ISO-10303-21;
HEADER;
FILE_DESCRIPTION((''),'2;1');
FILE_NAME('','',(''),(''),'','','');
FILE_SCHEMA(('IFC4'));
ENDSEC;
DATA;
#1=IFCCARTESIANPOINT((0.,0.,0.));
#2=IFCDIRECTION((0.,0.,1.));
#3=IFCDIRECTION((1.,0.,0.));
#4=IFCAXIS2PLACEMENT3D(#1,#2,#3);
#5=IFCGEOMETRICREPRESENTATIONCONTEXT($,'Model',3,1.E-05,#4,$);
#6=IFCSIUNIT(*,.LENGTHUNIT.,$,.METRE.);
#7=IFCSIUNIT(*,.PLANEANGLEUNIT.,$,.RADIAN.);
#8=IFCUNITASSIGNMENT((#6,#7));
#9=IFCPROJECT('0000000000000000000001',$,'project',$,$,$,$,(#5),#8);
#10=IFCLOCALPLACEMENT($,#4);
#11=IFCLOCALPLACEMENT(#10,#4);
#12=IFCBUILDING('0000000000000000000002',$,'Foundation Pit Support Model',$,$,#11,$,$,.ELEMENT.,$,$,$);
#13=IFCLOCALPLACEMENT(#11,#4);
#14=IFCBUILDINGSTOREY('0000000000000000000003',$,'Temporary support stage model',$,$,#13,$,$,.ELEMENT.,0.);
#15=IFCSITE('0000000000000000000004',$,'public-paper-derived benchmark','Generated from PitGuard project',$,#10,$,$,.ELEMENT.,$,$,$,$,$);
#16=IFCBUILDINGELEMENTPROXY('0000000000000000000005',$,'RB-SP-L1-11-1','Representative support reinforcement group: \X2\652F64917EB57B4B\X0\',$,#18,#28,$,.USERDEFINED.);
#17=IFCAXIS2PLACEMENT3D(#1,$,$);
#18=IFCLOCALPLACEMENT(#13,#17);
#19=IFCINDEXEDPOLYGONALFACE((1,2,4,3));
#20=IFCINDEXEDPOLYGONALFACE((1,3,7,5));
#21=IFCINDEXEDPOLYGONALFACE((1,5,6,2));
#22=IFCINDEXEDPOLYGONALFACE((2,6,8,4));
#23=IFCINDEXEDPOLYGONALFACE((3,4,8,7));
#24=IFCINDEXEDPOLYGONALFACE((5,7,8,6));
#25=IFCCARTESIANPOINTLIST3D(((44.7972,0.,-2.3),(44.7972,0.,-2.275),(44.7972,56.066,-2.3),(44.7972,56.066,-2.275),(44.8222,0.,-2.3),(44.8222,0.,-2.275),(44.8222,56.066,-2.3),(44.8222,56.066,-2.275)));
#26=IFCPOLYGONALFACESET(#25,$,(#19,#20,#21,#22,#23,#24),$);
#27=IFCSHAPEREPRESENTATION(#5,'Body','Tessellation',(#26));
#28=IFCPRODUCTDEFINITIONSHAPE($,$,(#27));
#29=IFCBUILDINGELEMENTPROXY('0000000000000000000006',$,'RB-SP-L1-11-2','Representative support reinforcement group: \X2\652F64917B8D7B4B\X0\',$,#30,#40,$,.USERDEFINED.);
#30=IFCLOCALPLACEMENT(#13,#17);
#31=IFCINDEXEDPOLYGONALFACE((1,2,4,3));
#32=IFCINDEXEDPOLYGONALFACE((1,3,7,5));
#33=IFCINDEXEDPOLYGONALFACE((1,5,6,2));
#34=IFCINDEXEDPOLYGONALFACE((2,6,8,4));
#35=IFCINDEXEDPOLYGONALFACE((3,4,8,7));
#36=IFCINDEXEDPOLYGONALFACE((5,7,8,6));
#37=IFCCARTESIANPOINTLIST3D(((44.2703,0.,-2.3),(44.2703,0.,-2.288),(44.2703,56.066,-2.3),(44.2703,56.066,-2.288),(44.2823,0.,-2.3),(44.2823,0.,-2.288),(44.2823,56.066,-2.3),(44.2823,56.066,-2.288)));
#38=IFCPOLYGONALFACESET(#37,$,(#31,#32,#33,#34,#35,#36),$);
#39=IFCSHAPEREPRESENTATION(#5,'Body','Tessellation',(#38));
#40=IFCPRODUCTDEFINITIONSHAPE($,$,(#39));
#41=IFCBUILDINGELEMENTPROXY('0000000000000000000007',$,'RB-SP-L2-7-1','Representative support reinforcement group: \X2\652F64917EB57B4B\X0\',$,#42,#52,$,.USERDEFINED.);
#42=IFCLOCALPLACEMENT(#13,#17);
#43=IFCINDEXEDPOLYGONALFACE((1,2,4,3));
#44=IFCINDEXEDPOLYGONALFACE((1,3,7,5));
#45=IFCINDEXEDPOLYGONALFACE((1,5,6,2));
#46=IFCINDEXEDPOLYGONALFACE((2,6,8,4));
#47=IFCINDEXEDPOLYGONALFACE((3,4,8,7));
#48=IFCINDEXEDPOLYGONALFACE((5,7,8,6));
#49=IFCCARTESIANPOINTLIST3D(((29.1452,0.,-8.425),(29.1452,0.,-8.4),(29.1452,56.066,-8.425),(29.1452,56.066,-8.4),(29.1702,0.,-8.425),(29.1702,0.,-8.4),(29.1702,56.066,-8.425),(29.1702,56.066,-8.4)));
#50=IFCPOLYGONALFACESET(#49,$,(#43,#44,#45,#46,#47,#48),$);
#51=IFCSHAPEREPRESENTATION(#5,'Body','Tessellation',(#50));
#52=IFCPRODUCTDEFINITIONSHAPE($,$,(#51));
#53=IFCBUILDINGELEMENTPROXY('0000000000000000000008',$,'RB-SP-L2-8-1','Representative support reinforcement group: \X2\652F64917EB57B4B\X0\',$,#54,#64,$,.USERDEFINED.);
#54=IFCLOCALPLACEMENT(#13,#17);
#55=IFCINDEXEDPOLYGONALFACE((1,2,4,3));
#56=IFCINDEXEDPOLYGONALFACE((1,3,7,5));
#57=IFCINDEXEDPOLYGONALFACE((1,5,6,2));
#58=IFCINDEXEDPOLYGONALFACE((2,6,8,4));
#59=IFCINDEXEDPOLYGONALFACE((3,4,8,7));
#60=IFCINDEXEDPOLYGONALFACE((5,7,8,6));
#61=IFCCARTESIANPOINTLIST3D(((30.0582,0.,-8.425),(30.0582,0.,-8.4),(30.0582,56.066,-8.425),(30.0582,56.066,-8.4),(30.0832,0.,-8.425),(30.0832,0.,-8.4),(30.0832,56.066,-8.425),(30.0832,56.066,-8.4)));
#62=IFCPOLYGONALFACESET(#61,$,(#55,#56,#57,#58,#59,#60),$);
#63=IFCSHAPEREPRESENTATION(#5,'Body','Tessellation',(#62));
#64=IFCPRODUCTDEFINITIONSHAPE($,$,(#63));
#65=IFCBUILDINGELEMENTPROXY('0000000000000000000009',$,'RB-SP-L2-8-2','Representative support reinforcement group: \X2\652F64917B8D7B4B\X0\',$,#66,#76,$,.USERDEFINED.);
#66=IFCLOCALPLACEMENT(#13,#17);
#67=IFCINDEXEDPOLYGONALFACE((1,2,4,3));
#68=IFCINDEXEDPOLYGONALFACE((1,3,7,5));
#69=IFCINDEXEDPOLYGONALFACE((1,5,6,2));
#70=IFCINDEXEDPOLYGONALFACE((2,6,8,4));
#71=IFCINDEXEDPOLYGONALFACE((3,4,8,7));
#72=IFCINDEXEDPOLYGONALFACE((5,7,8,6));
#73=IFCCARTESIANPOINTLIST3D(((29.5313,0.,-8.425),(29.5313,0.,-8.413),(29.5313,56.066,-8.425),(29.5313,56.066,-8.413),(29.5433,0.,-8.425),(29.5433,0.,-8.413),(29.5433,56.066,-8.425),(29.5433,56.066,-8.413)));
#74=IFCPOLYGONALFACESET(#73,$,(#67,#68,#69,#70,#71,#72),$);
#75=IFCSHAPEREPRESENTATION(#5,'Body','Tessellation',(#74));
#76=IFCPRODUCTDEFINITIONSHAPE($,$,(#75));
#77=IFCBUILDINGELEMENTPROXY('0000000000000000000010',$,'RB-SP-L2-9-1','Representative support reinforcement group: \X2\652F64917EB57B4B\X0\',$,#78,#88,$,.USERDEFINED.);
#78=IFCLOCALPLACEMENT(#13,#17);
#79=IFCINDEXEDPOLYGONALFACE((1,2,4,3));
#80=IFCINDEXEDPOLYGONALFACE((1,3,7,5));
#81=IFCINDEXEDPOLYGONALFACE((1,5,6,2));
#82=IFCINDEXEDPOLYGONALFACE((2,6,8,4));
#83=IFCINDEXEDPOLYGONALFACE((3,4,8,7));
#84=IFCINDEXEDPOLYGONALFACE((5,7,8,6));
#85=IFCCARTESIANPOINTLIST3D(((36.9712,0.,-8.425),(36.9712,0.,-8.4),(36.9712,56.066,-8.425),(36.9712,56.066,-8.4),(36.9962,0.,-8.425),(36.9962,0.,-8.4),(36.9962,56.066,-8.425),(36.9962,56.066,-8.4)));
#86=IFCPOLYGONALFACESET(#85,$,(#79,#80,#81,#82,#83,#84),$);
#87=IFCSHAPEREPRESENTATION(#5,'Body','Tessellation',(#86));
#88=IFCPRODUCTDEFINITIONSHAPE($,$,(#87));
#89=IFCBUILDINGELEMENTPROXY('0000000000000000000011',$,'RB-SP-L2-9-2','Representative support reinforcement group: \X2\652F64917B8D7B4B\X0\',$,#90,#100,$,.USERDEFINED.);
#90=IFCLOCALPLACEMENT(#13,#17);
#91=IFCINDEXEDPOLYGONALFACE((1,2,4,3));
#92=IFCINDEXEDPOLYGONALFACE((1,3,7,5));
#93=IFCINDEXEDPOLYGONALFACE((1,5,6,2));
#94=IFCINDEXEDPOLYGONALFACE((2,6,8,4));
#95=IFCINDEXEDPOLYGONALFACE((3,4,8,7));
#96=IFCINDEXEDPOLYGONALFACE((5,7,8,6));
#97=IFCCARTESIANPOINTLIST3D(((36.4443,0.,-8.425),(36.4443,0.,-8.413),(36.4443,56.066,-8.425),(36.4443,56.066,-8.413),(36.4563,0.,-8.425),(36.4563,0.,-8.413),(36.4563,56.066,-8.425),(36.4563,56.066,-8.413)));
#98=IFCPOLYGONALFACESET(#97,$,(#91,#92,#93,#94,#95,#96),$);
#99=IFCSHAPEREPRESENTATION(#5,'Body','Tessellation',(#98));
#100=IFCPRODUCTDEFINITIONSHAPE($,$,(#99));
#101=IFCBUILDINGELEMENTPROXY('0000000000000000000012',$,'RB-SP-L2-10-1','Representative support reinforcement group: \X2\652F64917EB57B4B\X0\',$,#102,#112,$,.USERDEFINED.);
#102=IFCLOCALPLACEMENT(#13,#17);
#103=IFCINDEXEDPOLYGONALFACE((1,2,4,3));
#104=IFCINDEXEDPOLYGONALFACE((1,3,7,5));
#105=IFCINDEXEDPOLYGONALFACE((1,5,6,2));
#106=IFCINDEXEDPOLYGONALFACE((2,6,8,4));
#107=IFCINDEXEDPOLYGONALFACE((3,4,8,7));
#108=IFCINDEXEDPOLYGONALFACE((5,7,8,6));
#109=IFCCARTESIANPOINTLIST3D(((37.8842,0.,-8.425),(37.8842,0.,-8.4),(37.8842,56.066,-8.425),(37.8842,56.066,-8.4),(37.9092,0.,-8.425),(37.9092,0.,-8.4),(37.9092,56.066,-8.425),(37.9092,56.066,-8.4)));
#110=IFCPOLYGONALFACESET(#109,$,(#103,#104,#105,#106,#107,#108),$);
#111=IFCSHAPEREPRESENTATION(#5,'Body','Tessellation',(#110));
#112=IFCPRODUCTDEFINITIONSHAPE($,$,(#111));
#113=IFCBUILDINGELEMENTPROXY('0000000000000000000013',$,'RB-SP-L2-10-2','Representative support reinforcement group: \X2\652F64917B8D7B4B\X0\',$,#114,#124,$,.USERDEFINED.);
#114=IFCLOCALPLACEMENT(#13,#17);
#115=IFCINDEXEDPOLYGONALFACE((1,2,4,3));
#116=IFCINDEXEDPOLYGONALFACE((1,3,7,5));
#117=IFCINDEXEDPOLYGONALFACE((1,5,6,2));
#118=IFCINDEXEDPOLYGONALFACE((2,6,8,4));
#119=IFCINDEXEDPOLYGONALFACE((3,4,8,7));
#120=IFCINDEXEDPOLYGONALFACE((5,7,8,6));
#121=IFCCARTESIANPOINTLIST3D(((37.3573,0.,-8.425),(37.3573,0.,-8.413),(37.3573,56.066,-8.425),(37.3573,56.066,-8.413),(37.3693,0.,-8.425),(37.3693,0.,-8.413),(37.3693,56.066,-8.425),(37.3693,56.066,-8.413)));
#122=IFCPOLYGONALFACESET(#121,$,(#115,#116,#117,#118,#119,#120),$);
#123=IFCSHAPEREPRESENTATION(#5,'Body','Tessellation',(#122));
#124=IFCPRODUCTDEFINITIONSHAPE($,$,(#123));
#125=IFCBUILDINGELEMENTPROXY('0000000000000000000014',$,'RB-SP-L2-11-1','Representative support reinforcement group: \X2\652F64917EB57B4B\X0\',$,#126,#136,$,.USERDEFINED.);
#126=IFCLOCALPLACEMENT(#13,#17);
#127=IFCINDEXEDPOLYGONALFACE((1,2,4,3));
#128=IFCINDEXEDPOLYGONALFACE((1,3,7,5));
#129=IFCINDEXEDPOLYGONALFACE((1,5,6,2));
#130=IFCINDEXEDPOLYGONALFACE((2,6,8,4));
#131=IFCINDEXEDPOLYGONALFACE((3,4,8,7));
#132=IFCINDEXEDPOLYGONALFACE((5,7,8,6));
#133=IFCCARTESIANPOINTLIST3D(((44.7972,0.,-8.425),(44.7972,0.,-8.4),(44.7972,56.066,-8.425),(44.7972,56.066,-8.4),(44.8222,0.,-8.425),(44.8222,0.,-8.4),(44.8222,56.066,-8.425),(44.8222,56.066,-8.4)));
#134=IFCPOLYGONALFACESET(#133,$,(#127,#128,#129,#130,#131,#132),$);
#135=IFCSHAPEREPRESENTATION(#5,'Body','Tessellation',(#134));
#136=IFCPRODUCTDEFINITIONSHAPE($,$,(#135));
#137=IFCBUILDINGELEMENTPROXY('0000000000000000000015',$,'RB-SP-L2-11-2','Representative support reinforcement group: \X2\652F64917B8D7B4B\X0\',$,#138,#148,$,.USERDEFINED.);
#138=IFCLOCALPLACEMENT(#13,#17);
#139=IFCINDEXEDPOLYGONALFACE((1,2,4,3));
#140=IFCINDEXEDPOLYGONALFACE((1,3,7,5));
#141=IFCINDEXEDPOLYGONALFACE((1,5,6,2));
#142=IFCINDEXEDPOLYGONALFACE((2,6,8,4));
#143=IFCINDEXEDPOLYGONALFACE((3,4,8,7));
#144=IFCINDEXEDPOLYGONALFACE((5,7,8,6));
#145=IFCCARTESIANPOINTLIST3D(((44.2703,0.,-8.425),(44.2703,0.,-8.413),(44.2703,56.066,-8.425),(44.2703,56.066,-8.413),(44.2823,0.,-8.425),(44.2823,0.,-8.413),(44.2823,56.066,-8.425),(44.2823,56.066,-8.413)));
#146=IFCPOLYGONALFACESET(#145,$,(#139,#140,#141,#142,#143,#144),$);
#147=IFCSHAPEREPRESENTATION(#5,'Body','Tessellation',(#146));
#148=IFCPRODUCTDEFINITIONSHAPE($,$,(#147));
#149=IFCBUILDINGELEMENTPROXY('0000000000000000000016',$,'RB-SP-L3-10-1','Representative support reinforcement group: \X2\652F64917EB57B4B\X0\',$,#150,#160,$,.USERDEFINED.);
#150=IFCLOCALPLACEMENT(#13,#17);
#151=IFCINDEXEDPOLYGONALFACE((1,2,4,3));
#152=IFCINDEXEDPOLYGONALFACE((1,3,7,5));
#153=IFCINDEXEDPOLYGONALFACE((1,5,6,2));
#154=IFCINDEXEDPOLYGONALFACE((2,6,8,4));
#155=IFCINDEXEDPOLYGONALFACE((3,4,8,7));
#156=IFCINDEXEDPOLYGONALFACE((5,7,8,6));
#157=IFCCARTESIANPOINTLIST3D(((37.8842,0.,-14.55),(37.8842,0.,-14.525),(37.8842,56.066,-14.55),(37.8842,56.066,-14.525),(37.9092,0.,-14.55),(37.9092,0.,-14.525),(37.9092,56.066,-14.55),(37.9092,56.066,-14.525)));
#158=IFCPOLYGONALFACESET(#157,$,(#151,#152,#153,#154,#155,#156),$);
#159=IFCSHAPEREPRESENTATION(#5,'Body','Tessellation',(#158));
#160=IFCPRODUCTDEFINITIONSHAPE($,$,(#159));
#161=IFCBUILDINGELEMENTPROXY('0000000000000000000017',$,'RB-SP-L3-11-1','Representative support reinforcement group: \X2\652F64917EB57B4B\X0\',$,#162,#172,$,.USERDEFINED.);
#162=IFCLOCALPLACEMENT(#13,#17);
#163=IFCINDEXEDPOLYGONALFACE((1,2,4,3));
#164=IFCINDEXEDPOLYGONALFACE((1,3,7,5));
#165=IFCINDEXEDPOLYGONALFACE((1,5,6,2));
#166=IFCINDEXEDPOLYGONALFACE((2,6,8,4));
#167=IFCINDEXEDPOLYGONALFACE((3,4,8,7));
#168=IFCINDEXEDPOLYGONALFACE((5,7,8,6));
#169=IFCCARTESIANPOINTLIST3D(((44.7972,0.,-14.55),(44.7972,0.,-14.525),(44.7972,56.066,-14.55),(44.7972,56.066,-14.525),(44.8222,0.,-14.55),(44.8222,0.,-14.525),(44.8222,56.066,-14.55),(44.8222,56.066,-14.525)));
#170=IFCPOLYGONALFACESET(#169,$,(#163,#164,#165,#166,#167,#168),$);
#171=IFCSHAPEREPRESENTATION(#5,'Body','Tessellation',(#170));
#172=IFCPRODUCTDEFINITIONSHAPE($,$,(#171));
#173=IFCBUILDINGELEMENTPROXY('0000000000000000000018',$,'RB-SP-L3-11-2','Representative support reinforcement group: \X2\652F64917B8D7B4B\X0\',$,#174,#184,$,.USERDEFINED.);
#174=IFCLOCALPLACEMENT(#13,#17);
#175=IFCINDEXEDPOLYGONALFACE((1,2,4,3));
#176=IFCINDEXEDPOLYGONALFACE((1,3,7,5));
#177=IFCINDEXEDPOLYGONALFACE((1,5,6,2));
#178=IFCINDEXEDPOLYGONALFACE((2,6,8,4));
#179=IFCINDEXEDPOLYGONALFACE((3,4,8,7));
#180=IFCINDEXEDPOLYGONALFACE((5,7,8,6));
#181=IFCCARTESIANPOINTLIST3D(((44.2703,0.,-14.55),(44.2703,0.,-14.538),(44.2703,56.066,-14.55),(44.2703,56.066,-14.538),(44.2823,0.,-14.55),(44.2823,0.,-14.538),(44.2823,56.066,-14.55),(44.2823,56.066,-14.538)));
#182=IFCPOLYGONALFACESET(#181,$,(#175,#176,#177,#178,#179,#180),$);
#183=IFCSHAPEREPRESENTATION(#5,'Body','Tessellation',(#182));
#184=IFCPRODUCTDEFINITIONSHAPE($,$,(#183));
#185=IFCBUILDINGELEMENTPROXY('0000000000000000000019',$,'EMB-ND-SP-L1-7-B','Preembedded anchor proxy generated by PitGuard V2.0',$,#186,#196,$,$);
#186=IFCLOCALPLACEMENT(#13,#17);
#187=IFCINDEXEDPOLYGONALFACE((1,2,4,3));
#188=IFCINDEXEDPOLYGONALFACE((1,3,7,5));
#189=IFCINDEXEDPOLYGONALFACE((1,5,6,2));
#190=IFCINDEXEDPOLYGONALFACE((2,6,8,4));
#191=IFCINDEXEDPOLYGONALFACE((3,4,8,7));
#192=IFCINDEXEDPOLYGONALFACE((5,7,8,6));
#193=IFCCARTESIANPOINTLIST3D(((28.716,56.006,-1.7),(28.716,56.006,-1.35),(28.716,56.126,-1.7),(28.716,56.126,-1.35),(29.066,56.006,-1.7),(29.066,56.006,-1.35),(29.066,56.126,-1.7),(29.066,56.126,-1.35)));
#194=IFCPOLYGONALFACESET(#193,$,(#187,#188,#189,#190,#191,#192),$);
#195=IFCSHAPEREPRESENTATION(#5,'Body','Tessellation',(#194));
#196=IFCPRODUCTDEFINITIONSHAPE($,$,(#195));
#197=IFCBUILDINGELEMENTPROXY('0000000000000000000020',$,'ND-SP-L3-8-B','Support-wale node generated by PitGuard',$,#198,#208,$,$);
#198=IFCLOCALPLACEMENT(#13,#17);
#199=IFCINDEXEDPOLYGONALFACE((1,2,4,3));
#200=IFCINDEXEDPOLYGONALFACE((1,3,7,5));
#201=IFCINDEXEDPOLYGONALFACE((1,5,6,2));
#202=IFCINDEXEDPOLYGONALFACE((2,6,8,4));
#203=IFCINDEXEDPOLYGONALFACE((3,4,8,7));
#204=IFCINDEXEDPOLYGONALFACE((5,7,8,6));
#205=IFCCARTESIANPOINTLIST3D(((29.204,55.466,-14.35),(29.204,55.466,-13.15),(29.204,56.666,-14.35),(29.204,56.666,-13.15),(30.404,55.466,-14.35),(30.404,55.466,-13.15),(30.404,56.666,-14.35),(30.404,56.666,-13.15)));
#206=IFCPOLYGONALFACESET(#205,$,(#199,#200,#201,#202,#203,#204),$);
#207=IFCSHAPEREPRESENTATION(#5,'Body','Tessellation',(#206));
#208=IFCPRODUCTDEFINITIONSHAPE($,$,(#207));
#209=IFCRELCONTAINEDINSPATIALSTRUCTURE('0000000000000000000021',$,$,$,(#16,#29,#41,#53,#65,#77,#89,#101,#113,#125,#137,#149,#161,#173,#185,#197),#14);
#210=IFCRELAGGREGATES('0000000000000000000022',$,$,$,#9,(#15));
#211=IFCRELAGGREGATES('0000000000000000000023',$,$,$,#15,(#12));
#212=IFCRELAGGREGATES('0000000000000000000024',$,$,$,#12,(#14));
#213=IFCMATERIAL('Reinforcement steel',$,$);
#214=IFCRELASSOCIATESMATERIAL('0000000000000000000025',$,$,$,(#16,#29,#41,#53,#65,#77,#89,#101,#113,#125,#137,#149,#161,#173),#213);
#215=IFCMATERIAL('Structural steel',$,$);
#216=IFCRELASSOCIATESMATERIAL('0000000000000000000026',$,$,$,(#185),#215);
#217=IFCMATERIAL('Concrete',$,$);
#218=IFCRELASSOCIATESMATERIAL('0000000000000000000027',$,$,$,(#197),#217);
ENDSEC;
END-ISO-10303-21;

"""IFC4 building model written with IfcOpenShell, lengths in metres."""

from ifc_helpers import new_model, si_unit, frame, origin_with_axes, origin_2d, place, context, project, spatial, rectangle, extrude, material, element, save


model = new_model("IFC4")

# Units and contexts
model_context = context("Model", 3, precision=1e-05, world=origin_with_axes())
ifc_project = project(units=[si_unit("LENGTHUNIT", "METRE"), si_unit("PLANEANGLEUNIT", "RADIAN")], contexts=[model_context])

# Site, building, storey
site_placement = place(None, origin_with_axes())
site = spatial("IfcSite", under=ifc_project, at=site_placement, Name="public-paper-derived benchmark", Description="Generated from PitGuard project", CompositionType="ELEMENT")
building_placement = place(site_placement, origin_with_axes())
building = spatial("IfcBuilding", under=site, at=building_placement, Name="Foundation Pit Support Model", CompositionType="ELEMENT")
storey_placement = place(building_placement, origin_with_axes())
storey = spatial("IfcBuildingStorey", under=building, at=storey_placement, Name="Temporary support stage model", CompositionType="ELEMENT", Elevation=0.0)

# Shared definitions
ifc_material_1 = material(Name="Concrete")

# Shared definitions
ifc_material_2 = material(Name="Structural steel")

# Building element proxies
ifc_material_3 = material(Name="Reinforcement steel")
proxy_1_placement = place(storey_placement, frame((44.8097, 28.033, -2.3), z_axis=(0.0, 0.0, 1.0), x_axis=(0.0, 1.0, 0.0)))
element("IfcBuildingElementProxy", 1, at=proxy_1_placement, inside=storey, material=ifc_material_3, Name="RB-SP-L1-11-1", Description="Representative support reinforcement group: 支撑纵筋", PredefinedType="USERDEFINED", context=model_context, shape_type="SweptSolid", body=[
    extrude(rectangle(XDim=56.066, YDim=0.025, at=origin_2d()), origin_with_axes(), (0.0, 0.0, 1.0), 0.025),
])
proxy_2_placement = place(storey_placement, frame((44.2763, 28.033, -2.3), z_axis=(0.0, 0.0, 1.0), x_axis=(0.0, 1.0, 0.0)))
element("IfcBuildingElementProxy", 2, at=proxy_2_placement, inside=storey, material=ifc_material_3, Name="RB-SP-L1-11-2", Description="Representative support reinforcement group: 支撑箍筋", PredefinedType="USERDEFINED", context=model_context, shape_type="SweptSolid", body=[
    extrude(rectangle(XDim=56.066, YDim=0.012, at=origin_2d()), origin_with_axes(), (0.0, 0.0, 1.0), 0.012),
])
for number, where, z_axis, x_axis, name in (
    (3, (29.1577, 28.033, -8.425), (0.0, 0.0, 1.0), (0.0, 1.0, 0.0), "RB-SP-L2-7-1"),
    (4, (30.0707, 28.033, -8.425), (0.0, 0.0, 1.0), (0.0, 1.0, 0.0), "RB-SP-L2-8-1"),
):
    element("IfcBuildingElementProxy", number, at=place(storey_placement, frame(where, z_axis=z_axis, x_axis=x_axis)), inside=storey, material=ifc_material_3, Name=name, Description="Representative support reinforcement group: 支撑纵筋", PredefinedType="USERDEFINED", context=model_context, shape_type="SweptSolid", body=[
        extrude(rectangle(XDim=56.066, YDim=0.025, at=origin_2d()), origin_with_axes(), (0.0, 0.0, 1.0), 0.025),
    ])
proxy_3_placement = place(storey_placement, frame((29.5373, 28.033, -8.425), z_axis=(0.0, 0.0, 1.0), x_axis=(0.0, 1.0, 0.0)))
element("IfcBuildingElementProxy", 5, at=proxy_3_placement, inside=storey, material=ifc_material_3, Name="RB-SP-L2-8-2", Description="Representative support reinforcement group: 支撑箍筋", PredefinedType="USERDEFINED", context=model_context, shape_type="SweptSolid", body=[
    extrude(rectangle(XDim=56.066, YDim=0.012, at=origin_2d()), origin_with_axes(), (0.0, 0.0, 1.0), 0.012),
])
proxy_4_placement = place(storey_placement, frame((36.9837, 28.033, -8.425), z_axis=(0.0, 0.0, 1.0), x_axis=(0.0, 1.0, 0.0)))
element("IfcBuildingElementProxy", 6, at=proxy_4_placement, inside=storey, material=ifc_material_3, Name="RB-SP-L2-9-1", Description="Representative support reinforcement group: 支撑纵筋", PredefinedType="USERDEFINED", context=model_context, shape_type="SweptSolid", body=[
    extrude(rectangle(XDim=56.066, YDim=0.025, at=origin_2d()), origin_with_axes(), (0.0, 0.0, 1.0), 0.025),
])
proxy_5_placement = place(storey_placement, frame((36.4503, 28.033, -8.425), z_axis=(0.0, 0.0, 1.0), x_axis=(0.0, 1.0, 0.0)))
element("IfcBuildingElementProxy", 7, at=proxy_5_placement, inside=storey, material=ifc_material_3, Name="RB-SP-L2-9-2", Description="Representative support reinforcement group: 支撑箍筋", PredefinedType="USERDEFINED", context=model_context, shape_type="SweptSolid", body=[
    extrude(rectangle(XDim=56.066, YDim=0.012, at=origin_2d()), origin_with_axes(), (0.0, 0.0, 1.0), 0.012),
])
proxy_6_placement = place(storey_placement, frame((37.8967, 28.033, -8.425), z_axis=(0.0, 0.0, 1.0), x_axis=(0.0, 1.0, 0.0)))
element("IfcBuildingElementProxy", 8, at=proxy_6_placement, inside=storey, material=ifc_material_3, Name="RB-SP-L2-10-1", Description="Representative support reinforcement group: 支撑纵筋", PredefinedType="USERDEFINED", context=model_context, shape_type="SweptSolid", body=[
    extrude(rectangle(XDim=56.066, YDim=0.025, at=origin_2d()), origin_with_axes(), (0.0, 0.0, 1.0), 0.025),
])
proxy_7_placement = place(storey_placement, frame((37.3633, 28.033, -8.425), z_axis=(0.0, 0.0, 1.0), x_axis=(0.0, 1.0, 0.0)))
element("IfcBuildingElementProxy", 9, at=proxy_7_placement, inside=storey, material=ifc_material_3, Name="RB-SP-L2-10-2", Description="Representative support reinforcement group: 支撑箍筋", PredefinedType="USERDEFINED", context=model_context, shape_type="SweptSolid", body=[
    extrude(rectangle(XDim=56.066, YDim=0.012, at=origin_2d()), origin_with_axes(), (0.0, 0.0, 1.0), 0.012),
])
proxy_8_placement = place(storey_placement, frame((44.8097, 28.033, -8.425), z_axis=(0.0, 0.0, 1.0), x_axis=(0.0, 1.0, 0.0)))
element("IfcBuildingElementProxy", 10, at=proxy_8_placement, inside=storey, material=ifc_material_3, Name="RB-SP-L2-11-1", Description="Representative support reinforcement group: 支撑纵筋", PredefinedType="USERDEFINED", context=model_context, shape_type="SweptSolid", body=[
    extrude(rectangle(XDim=56.066, YDim=0.025, at=origin_2d()), origin_with_axes(), (0.0, 0.0, 1.0), 0.025),
])
proxy_9_placement = place(storey_placement, frame((44.2763, 28.033, -8.425), z_axis=(0.0, 0.0, 1.0), x_axis=(0.0, 1.0, 0.0)))
element("IfcBuildingElementProxy", 11, at=proxy_9_placement, inside=storey, material=ifc_material_3, Name="RB-SP-L2-11-2", Description="Representative support reinforcement group: 支撑箍筋", PredefinedType="USERDEFINED", context=model_context, shape_type="SweptSolid", body=[
    extrude(rectangle(XDim=56.066, YDim=0.012, at=origin_2d()), origin_with_axes(), (0.0, 0.0, 1.0), 0.012),
])
for number, where, z_axis, x_axis, name in (
    (12, (37.8967, 28.033, -14.55), (0.0, 0.0, 1.0), (0.0, 1.0, 0.0), "RB-SP-L3-10-1"),
    (13, (44.8097, 28.033, -14.55), (0.0, 0.0, 1.0), (0.0, 1.0, 0.0), "RB-SP-L3-11-1"),
):
    element("IfcBuildingElementProxy", number, at=place(storey_placement, frame(where, z_axis=z_axis, x_axis=x_axis)), inside=storey, material=ifc_material_3, Name=name, Description="Representative support reinforcement group: 支撑纵筋", PredefinedType="USERDEFINED", context=model_context, shape_type="SweptSolid", body=[
        extrude(rectangle(XDim=56.066, YDim=0.025, at=origin_2d()), origin_with_axes(), (0.0, 0.0, 1.0), 0.025),
    ])
proxy_10_placement = place(storey_placement, frame((44.2763, 28.033, -14.55), z_axis=(0.0, 0.0, 1.0), x_axis=(0.0, 1.0, 0.0)))
element("IfcBuildingElementProxy", 14, at=proxy_10_placement, inside=storey, material=ifc_material_3, Name="RB-SP-L3-11-2", Description="Representative support reinforcement group: 支撑箍筋", PredefinedType="USERDEFINED", context=model_context, shape_type="SweptSolid", body=[
    extrude(rectangle(XDim=56.066, YDim=0.012, at=origin_2d()), origin_with_axes(), (0.0, 0.0, 1.0), 0.012),
])
proxy_11_placement = place(storey_placement, frame((28.891, 56.066, -1.7), z_axis=(0.0, 0.0, 1.0), x_axis=(1.0, 0.0, 0.0)))
element("IfcBuildingElementProxy", 15, at=proxy_11_placement, inside=storey, material=ifc_material_2, Name="EMB-ND-SP-L1-7-B", Description="Preembedded anchor proxy generated by PitGuard V2.0", context=model_context, shape_type="SweptSolid", body=[
    extrude(rectangle(XDim=0.35, YDim=0.12, at=origin_2d()), origin_with_axes(), (0.0, 0.0, 1.0), 0.35),
])
proxy_12_placement = place(storey_placement, frame((29.804, 56.066, -14.35), z_axis=(0.0, 0.0, 1.0), x_axis=(1.0, 0.0, 0.0)))
element("IfcBuildingElementProxy", 16, at=proxy_12_placement, inside=storey, material=ifc_material_1, Name="ND-SP-L3-8-B", Description="Support-wale node generated by PitGuard", context=model_context, shape_type="SweptSolid", body=[
    extrude(rectangle(XDim=1.2, YDim=1.2, at=origin_2d()), origin_with_axes(), (0.0, 0.0, 1.0), 1.2),
])

save(model, "model.ifc")
